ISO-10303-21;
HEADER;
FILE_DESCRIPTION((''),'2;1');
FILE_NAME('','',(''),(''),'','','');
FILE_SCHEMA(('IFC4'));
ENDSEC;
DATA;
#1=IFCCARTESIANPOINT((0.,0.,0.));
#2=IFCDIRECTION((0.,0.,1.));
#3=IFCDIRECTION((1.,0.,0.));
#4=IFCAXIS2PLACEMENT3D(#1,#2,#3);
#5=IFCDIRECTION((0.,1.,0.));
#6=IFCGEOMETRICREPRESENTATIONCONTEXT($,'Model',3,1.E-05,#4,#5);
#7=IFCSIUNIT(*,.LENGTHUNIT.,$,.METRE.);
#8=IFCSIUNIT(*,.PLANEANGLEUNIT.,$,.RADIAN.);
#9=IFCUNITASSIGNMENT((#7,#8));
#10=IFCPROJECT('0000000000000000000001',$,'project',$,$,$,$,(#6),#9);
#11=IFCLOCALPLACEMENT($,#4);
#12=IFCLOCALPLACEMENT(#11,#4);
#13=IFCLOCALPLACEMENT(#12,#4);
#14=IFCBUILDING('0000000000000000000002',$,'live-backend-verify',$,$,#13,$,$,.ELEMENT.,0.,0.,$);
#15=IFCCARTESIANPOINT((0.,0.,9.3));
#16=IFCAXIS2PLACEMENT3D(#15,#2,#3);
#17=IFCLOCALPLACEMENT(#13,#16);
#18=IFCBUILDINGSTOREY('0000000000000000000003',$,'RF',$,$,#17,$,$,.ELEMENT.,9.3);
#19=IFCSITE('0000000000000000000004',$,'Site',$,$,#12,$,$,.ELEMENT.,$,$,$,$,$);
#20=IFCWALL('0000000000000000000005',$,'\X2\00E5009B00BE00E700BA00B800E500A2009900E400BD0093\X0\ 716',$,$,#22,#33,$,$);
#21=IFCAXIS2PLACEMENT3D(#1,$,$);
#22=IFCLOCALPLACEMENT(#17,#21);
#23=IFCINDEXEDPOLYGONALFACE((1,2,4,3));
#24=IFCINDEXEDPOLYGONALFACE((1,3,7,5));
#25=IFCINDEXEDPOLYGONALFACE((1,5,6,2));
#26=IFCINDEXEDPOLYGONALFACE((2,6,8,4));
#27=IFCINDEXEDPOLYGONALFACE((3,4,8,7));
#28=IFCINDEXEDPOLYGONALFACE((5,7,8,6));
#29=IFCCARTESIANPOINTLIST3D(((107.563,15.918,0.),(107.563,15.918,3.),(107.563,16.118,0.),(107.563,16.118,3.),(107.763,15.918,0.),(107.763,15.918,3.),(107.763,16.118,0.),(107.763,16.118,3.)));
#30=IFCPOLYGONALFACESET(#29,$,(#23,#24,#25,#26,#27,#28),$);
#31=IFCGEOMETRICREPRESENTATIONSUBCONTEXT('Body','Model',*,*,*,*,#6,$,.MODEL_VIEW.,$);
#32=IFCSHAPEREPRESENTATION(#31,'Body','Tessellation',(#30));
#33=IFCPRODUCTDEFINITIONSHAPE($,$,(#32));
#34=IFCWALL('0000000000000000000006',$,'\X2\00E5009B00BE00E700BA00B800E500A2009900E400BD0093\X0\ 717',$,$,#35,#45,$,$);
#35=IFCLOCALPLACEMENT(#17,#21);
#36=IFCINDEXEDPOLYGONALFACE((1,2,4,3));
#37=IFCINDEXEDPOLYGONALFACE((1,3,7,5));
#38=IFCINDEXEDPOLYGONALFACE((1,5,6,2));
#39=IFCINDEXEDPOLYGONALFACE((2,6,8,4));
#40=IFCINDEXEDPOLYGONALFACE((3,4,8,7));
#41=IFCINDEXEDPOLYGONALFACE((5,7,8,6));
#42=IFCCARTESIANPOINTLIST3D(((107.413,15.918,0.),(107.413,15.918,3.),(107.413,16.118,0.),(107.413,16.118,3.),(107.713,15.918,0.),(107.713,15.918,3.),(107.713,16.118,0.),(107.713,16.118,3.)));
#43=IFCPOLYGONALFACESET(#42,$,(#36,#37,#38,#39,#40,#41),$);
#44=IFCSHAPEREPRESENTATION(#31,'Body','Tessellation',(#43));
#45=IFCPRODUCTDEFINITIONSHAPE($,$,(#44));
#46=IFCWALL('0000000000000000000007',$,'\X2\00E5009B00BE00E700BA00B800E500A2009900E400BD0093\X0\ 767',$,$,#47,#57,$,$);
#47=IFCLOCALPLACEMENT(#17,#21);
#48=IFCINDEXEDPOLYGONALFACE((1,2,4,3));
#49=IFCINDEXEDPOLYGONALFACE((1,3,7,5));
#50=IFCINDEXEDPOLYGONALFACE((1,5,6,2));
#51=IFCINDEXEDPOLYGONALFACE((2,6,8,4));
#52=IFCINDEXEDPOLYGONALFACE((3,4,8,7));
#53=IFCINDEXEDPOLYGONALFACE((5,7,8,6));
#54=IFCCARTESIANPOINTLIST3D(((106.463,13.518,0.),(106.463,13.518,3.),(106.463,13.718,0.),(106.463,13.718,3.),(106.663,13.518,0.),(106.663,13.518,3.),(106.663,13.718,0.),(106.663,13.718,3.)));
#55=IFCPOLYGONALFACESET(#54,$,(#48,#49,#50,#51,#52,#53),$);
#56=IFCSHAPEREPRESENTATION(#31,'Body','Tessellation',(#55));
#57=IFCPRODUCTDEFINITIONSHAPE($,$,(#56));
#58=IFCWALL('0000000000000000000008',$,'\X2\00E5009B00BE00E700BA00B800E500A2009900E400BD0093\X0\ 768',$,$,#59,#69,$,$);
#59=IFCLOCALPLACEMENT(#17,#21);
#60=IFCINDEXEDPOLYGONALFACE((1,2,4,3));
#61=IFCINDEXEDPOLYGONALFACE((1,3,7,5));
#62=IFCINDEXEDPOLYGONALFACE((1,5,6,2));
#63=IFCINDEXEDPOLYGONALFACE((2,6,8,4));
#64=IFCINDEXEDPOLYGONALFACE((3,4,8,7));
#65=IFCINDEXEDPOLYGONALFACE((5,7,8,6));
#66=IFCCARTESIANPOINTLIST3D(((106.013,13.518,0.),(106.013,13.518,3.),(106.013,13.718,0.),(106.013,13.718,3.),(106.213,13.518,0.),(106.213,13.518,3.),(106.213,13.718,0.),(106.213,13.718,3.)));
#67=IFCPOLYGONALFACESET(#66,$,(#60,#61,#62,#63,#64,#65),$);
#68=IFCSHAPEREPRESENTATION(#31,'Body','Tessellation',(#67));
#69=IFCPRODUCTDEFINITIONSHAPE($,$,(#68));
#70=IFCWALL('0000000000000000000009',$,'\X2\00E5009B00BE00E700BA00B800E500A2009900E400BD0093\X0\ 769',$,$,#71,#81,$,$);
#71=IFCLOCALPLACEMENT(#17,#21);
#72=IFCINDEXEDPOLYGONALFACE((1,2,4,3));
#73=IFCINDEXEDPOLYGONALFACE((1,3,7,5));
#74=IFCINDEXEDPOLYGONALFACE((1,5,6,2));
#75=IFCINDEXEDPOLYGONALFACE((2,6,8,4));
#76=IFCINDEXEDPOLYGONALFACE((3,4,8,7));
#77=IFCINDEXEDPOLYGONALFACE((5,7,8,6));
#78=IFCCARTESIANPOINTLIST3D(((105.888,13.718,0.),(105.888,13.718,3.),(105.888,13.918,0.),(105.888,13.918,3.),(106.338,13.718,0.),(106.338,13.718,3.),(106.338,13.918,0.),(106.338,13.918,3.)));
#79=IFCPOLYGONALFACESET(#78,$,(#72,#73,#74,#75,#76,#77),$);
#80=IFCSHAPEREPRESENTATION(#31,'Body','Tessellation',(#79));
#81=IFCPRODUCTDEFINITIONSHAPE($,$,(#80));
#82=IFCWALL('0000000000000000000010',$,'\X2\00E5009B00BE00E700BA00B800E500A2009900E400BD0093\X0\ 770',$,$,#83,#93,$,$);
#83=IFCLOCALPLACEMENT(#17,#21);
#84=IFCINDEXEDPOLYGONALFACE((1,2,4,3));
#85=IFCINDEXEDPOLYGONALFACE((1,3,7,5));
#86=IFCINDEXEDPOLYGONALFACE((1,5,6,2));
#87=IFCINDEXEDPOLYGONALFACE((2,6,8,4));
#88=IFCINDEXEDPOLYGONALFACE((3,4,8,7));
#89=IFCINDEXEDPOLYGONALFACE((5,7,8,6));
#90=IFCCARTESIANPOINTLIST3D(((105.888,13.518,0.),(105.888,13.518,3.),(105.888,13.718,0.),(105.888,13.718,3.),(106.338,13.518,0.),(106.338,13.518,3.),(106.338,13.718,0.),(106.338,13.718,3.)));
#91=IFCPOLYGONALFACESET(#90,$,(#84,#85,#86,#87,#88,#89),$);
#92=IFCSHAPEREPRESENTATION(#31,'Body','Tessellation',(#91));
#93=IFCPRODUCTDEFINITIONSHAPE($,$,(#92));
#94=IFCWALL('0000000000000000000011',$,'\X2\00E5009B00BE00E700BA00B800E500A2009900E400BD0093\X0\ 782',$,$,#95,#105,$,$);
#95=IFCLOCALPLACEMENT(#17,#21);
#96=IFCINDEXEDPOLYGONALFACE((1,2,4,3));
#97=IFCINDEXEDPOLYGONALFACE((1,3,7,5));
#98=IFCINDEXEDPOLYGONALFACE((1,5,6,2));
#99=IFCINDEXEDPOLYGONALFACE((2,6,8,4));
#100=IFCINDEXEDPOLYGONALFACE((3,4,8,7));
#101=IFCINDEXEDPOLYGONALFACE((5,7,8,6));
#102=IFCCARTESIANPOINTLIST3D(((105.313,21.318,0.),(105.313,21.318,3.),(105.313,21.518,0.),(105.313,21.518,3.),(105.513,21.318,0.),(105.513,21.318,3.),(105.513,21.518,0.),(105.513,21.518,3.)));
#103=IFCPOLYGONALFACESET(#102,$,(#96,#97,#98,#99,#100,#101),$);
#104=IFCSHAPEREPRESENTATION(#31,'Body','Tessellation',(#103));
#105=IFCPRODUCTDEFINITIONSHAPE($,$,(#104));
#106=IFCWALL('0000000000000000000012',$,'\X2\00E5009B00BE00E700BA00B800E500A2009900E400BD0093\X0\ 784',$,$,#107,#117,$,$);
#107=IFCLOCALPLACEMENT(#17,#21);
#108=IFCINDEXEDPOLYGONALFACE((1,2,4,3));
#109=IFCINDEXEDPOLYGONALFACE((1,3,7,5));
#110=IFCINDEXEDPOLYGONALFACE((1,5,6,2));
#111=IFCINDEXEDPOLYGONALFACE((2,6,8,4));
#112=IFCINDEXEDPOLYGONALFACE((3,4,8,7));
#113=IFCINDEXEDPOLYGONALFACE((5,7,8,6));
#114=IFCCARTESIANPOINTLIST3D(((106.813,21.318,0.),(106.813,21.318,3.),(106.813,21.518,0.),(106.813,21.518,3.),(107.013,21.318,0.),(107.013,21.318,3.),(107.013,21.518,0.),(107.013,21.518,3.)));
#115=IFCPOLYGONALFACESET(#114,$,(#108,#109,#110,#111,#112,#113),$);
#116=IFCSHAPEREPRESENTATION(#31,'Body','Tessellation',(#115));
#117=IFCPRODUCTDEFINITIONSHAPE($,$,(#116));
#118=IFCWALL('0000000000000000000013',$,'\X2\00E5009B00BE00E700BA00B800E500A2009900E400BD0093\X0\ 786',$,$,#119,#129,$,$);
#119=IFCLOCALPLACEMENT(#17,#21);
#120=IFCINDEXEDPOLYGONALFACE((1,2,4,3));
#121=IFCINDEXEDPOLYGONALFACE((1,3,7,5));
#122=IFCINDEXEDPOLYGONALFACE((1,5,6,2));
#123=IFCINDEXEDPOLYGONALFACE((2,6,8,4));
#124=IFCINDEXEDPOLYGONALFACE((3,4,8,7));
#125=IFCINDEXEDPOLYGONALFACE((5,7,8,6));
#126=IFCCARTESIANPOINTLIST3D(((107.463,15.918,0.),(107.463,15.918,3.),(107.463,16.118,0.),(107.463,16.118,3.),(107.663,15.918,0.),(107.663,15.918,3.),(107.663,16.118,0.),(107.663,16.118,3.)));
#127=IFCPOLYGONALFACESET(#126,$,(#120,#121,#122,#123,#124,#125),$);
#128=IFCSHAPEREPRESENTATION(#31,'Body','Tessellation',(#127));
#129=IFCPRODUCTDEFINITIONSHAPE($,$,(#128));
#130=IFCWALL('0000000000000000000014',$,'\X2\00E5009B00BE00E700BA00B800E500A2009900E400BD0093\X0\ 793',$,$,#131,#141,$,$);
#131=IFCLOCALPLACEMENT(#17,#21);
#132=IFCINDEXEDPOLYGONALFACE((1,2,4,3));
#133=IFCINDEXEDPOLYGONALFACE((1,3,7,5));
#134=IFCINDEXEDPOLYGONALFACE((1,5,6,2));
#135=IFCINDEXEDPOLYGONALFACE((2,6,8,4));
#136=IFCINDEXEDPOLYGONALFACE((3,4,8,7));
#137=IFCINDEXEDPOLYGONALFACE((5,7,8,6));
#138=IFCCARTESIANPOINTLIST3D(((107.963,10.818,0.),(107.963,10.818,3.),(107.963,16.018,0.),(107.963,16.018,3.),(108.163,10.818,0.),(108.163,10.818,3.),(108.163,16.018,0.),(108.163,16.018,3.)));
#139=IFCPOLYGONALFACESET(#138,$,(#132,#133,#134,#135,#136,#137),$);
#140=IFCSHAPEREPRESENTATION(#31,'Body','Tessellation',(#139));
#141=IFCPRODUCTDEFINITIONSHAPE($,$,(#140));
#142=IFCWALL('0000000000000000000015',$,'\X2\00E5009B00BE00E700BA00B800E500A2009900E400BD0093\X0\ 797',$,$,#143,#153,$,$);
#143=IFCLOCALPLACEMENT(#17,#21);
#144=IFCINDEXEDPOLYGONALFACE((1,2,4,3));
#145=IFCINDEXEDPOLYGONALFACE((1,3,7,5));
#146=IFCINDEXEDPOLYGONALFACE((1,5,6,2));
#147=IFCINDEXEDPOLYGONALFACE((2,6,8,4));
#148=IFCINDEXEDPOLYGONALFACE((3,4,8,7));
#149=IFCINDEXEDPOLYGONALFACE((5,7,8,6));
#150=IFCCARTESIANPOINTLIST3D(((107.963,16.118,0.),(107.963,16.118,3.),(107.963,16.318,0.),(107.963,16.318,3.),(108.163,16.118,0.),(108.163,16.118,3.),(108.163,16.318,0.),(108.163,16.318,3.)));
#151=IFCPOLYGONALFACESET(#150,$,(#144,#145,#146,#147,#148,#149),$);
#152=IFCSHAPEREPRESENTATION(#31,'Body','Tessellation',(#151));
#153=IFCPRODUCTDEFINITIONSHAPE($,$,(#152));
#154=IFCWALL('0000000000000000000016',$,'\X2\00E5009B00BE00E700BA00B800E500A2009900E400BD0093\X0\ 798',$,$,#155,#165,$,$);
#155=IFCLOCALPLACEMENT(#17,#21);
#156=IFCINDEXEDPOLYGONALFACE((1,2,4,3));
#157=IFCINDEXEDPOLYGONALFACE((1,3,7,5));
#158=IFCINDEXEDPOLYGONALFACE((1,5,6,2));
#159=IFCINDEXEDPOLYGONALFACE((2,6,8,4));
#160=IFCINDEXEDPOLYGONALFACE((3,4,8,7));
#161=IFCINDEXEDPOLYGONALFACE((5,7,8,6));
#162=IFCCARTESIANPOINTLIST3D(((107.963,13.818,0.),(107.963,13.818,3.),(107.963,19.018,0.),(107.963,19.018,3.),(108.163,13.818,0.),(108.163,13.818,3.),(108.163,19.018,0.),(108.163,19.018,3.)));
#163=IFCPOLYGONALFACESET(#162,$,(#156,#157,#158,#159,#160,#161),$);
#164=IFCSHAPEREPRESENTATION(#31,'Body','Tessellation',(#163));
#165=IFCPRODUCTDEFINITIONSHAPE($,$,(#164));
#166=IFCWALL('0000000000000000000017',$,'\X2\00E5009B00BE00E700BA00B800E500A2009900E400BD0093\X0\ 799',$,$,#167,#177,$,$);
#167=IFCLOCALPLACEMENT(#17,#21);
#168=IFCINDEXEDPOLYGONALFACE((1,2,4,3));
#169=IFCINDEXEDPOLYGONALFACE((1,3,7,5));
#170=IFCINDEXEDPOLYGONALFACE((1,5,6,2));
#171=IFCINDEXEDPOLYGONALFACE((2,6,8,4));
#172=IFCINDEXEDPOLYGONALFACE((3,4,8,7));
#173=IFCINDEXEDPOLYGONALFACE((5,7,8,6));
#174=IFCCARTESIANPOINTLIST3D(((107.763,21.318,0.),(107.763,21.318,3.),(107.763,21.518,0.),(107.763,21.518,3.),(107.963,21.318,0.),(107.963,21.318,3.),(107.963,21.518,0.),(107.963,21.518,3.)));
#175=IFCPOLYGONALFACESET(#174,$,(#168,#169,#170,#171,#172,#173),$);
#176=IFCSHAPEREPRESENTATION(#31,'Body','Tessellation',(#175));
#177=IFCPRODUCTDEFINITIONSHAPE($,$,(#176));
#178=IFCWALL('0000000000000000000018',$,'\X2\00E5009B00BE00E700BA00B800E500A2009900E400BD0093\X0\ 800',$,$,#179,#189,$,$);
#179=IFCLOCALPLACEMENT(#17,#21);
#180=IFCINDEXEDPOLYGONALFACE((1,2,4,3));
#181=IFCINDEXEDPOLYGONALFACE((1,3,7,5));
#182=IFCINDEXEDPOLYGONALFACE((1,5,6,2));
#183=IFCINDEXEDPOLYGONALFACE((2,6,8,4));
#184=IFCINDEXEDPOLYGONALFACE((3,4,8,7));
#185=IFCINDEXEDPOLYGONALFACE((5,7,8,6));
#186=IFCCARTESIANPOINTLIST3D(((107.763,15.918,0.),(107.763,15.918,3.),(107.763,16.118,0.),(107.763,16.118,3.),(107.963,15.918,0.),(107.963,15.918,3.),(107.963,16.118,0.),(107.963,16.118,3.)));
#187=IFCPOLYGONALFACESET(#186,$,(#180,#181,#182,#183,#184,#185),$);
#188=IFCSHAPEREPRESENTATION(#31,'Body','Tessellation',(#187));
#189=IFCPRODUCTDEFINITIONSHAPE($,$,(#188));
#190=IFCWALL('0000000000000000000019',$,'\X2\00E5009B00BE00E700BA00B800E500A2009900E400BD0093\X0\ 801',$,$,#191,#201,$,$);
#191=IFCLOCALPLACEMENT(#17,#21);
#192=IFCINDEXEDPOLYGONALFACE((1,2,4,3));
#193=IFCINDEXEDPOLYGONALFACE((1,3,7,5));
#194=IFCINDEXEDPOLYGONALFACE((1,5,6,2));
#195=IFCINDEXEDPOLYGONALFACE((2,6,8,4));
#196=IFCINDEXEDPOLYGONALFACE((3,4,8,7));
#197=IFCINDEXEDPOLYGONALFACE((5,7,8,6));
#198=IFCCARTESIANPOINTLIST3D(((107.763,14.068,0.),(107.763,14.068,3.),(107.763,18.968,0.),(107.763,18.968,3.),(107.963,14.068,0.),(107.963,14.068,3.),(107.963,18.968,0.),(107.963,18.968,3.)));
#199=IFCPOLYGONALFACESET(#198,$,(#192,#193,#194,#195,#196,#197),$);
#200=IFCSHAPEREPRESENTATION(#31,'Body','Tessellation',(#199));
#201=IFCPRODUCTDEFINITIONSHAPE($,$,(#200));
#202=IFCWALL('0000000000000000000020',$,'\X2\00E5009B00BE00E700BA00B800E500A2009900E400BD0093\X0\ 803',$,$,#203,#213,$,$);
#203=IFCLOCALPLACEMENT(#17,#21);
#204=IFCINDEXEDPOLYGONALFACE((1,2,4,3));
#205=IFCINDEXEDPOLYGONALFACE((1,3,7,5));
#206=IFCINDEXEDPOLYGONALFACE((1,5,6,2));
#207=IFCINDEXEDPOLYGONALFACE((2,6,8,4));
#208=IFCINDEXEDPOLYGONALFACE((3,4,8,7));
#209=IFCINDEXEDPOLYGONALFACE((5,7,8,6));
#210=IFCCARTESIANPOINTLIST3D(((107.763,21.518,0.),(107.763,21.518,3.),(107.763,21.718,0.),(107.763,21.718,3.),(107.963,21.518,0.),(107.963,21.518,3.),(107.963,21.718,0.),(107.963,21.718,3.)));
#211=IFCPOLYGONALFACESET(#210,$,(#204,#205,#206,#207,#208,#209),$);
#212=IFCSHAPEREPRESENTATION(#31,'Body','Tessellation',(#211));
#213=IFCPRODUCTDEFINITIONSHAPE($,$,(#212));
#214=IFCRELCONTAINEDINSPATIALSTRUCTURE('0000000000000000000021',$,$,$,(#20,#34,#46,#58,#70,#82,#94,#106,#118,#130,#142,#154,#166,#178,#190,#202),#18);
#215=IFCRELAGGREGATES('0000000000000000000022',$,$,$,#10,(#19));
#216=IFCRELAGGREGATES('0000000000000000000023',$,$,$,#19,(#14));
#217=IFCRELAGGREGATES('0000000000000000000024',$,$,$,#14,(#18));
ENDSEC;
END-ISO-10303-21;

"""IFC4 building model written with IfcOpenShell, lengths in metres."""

from ifc_helpers import new_model, si_unit, direction, frame, frame_2d, origin_with_axes, place, context, subcontext, project, spatial, rectangle, extrude, element, save


model = new_model("IFC4")

# Units and contexts
model_context = context("Model", 3, precision=1e-05, world=origin_with_axes(), true_north=direction((0.0, 1.0, 0.0)))
body_context = subcontext(model_context, "Body", "Model", "MODEL_VIEW")
ifc_project = project(units=[si_unit("LENGTHUNIT", "METRE"), si_unit("PLANEANGLEUNIT", "RADIAN")], contexts=[model_context])

# Site, building, storey
placement = place(None, origin_with_axes())
site_placement = place(placement, origin_with_axes())
site = spatial("IfcSite", under=ifc_project, at=site_placement, Name="Site", CompositionType="ELEMENT")
building_placement = place(site_placement, origin_with_axes())
building = spatial("IfcBuilding", under=site, at=building_placement, Name="live-backend-verify", CompositionType="ELEMENT", ElevationOfRefHeight=0.0, ElevationOfTerrain=0.0)
storey_placement = place(building_placement, frame((0.0, 0.0, 9.3), z_axis=(0.0, 0.0, 1.0), x_axis=(1.0, 0.0, 0.0)))
storey = spatial("IfcBuildingStorey", under=building, at=storey_placement, Name="RF", CompositionType="ELEMENT", Elevation=9.3)

# Walls
wall_1_placement = place(storey_placement, frame((107.663, 16.018, 0.0), z_axis=(0.0, 0.0, 1.0), x_axis=(-1.0, 0.0, 0.0)))
element("IfcWall", 1, at=wall_1_placement, inside=storey, Name="å\u009b¾çº¸å¢\u0099ä½\u0093 716", context=body_context, shape_type="SweptSolid", body=[
    extrude(rectangle(XDim=0.2, YDim=0.2, at=frame_2d((0.0, 0.0), x_axis=(1.0, 0.0, 0.0))), frame((0.0, 0.0, 0.0), z_axis=(0.0, 0.0, 1.0)), (0.0, 0.0, 1.0), 3.0),
])
wall_2_placement = place(storey_placement, frame((107.563, 16.018, 0.0), z_axis=(0.0, 0.0, 1.0), x_axis=(1.0, 0.0, 0.0)))
element("IfcWall", 2, at=wall_2_placement, inside=storey, Name="å\u009b¾çº¸å¢\u0099ä½\u0093 717", context=body_context, shape_type="SweptSolid", body=[
    extrude(rectangle(XDim=0.3, YDim=0.2, at=frame_2d((0.0, 0.0), x_axis=(1.0, 0.0, 0.0))), frame((0.0, 0.0, 0.0), z_axis=(0.0, 0.0, 1.0)), (0.0, 0.0, 1.0), 3.0),
])
for number, where, z_axis, x_axis, name in (
    (3, (106.563, 13.618, 0.0), (0.0, 0.0, 1.0), (0.0, 1.0, 0.0), "å\u009b¾çº¸å¢\u0099ä½\u0093 767"),
    (4, (106.113, 13.618, 0.0), (0.0, 0.0, 1.0), (0.0, 1.0, 0.0), "å\u009b¾çº¸å¢\u0099ä½\u0093 768"),
):
    element("IfcWall", number, at=place(storey_placement, frame(where, z_axis=z_axis, x_axis=x_axis)), inside=storey, Name=name, context=body_context, shape_type="SweptSolid", body=[
        extrude(rectangle(XDim=0.2, YDim=0.2, at=frame_2d((0.0, 0.0), x_axis=(1.0, 0.0, 0.0))), frame((0.0, 0.0, 0.0), z_axis=(0.0, 0.0, 1.0)), (0.0, 0.0, 1.0), 3.0),
    ])
for number, where, z_axis, x_axis, name in (
    (5, (106.113, 13.818, 0.0), (0.0, 0.0, 1.0), (1.0, 0.0, 0.0), "å\u009b¾çº¸å¢\u0099ä½\u0093 769"),
    (6, (106.113, 13.618, 0.0), (0.0, 0.0, 1.0), (1.0, 0.0, 0.0), "å\u009b¾çº¸å¢\u0099ä½\u0093 770"),
):
    element("IfcWall", number, at=place(storey_placement, frame(where, z_axis=z_axis, x_axis=x_axis)), inside=storey, Name=name, context=body_context, shape_type="SweptSolid", body=[
        extrude(rectangle(XDim=0.45, YDim=0.2, at=frame_2d((0.0, 0.0), x_axis=(1.0, 0.0, 0.0))), frame((0.0, 0.0, 0.0), z_axis=(0.0, 0.0, 1.0)), (0.0, 0.0, 1.0), 3.0),
    ])
for number, where, z_axis, x_axis, name in (
    (7, (105.413, 21.418, 0.0), (0.0, 0.0, 1.0), (0.0, 1.0, 0.0), "å\u009b¾çº¸å¢\u0099ä½\u0093 782"),
    (8, (106.913, 21.418, 0.0), (0.0, 0.0, 1.0), (0.0, 1.0, 0.0), "å\u009b¾çº¸å¢\u0099ä½\u0093 784"),
    (9, (107.563, 16.018, 0.0), (0.0, 0.0, 1.0), (0.0, 1.0, 0.0), "å\u009b¾çº¸å¢\u0099ä½\u0093 786"),
):
    element("IfcWall", number, at=place(storey_placement, frame(where, z_axis=z_axis, x_axis=x_axis)), inside=storey, Name=name, context=body_context, shape_type="SweptSolid", body=[
        extrude(rectangle(XDim=0.2, YDim=0.2, at=frame_2d((0.0, 0.0), x_axis=(1.0, 0.0, 0.0))), frame((0.0, 0.0, 0.0), z_axis=(0.0, 0.0, 1.0)), (0.0, 0.0, 1.0), 3.0),
    ])
wall_3_placement = place(storey_placement, frame((108.063, 13.418, 0.0), z_axis=(0.0, 0.0, 1.0), x_axis=(0.0, -1.0, 0.0)))
element("IfcWall", 10, at=wall_3_placement, inside=storey, Name="å\u009b¾çº¸å¢\u0099ä½\u0093 793", context=body_context, shape_type="SweptSolid", body=[
    extrude(rectangle(XDim=5.2, YDim=0.2, at=frame_2d((0.0, 0.0), x_axis=(1.0, 0.0, 0.0))), frame((0.0, 0.0, 0.0), z_axis=(0.0, 0.0, 1.0)), (0.0, 0.0, 1.0), 3.0),
])
wall_4_placement = place(storey_placement, frame((108.063, 16.218, 0.0), z_axis=(0.0, 0.0, 1.0), x_axis=(0.0, -1.0, 0.0)))
element("IfcWall", 11, at=wall_4_placement, inside=storey, Name="å\u009b¾çº¸å¢\u0099ä½\u0093 797", context=body_context, shape_type="SweptSolid", body=[
    extrude(rectangle(XDim=0.2, YDim=0.2, at=frame_2d((0.0, 0.0), x_axis=(1.0, 0.0, 0.0))), frame((0.0, 0.0, 0.0), z_axis=(0.0, 0.0, 1.0)), (0.0, 0.0, 1.0), 3.0),
])
wall_5_placement = place(storey_placement, frame((108.063, 16.418, 0.0), z_axis=(0.0, 0.0, 1.0), x_axis=(0.0, 1.0, 0.0)))
element("IfcWall", 12, at=wall_5_placement, inside=storey, Name="å\u009b¾çº¸å¢\u0099ä½\u0093 798", context=body_context, shape_type="SweptSolid", body=[
    extrude(rectangle(XDim=5.2, YDim=0.2, at=frame_2d((0.0, 0.0), x_axis=(1.0, 0.0, 0.0))), frame((0.0, 0.0, 0.0), z_axis=(0.0, 0.0, 1.0)), (0.0, 0.0, 1.0), 3.0),
])
for number, where, z_axis, x_axis, name in (
    (13, (107.863, 21.418, 0.0), (0.0, 0.0, 1.0), (0.0, 1.0, 0.0), "å\u009b¾çº¸å¢\u0099ä½\u0093 799"),
    (14, (107.863, 16.018, 0.0), (0.0, 0.0, 1.0), (1.0, 0.0, 0.0), "å\u009b¾çº¸å¢\u0099ä½\u0093 800"),
):
    element("IfcWall", number, at=place(storey_placement, frame(where, z_axis=z_axis, x_axis=x_axis)), inside=storey, Name=name, context=body_context, shape_type="SweptSolid", body=[
        extrude(rectangle(XDim=0.2, YDim=0.2, at=frame_2d((0.0, 0.0), x_axis=(1.0, 0.0, 0.0))), frame((0.0, 0.0, 0.0), z_axis=(0.0, 0.0, 1.0)), (0.0, 0.0, 1.0), 3.0),
    ])
wall_6_placement = place(storey_placement, frame((107.863, 16.518, 0.0), z_axis=(0.0, 0.0, 1.0), x_axis=(0.0, 1.0, 0.0)))
element("IfcWall", 15, at=wall_6_placement, inside=storey, Name="å\u009b¾çº¸å¢\u0099ä½\u0093 801", context=body_context, shape_type="SweptSolid", body=[
    extrude(rectangle(XDim=4.9, YDim=0.2, at=frame_2d((0.0, 0.0), x_axis=(1.0, 0.0, 0.0))), frame((0.0, 0.0, 0.0), z_axis=(0.0, 0.0, 1.0)), (0.0, 0.0, 1.0), 3.0),
])
for number, where, z_axis, x_axis, name in (
    (16, (107.863, 21.618, 0.0), (0.0, 0.0, 1.0), (1.0, 0.0, 0.0), "å\u009b¾çº¸å¢\u0099ä½\u0093 803"),
):
    element("IfcWall", number, at=place(storey_placement, frame(where, z_axis=z_axis, x_axis=x_axis)), inside=storey, Name=name, context=body_context, shape_type="SweptSolid", body=[
        extrude(rectangle(XDim=0.2, YDim=0.2, at=frame_2d((0.0, 0.0), x_axis=(1.0, 0.0, 0.0))), frame((0.0, 0.0, 0.0), z_axis=(0.0, 0.0, 1.0)), (0.0, 0.0, 1.0), 3.0),
    ])

save(model, "model.ifc")
